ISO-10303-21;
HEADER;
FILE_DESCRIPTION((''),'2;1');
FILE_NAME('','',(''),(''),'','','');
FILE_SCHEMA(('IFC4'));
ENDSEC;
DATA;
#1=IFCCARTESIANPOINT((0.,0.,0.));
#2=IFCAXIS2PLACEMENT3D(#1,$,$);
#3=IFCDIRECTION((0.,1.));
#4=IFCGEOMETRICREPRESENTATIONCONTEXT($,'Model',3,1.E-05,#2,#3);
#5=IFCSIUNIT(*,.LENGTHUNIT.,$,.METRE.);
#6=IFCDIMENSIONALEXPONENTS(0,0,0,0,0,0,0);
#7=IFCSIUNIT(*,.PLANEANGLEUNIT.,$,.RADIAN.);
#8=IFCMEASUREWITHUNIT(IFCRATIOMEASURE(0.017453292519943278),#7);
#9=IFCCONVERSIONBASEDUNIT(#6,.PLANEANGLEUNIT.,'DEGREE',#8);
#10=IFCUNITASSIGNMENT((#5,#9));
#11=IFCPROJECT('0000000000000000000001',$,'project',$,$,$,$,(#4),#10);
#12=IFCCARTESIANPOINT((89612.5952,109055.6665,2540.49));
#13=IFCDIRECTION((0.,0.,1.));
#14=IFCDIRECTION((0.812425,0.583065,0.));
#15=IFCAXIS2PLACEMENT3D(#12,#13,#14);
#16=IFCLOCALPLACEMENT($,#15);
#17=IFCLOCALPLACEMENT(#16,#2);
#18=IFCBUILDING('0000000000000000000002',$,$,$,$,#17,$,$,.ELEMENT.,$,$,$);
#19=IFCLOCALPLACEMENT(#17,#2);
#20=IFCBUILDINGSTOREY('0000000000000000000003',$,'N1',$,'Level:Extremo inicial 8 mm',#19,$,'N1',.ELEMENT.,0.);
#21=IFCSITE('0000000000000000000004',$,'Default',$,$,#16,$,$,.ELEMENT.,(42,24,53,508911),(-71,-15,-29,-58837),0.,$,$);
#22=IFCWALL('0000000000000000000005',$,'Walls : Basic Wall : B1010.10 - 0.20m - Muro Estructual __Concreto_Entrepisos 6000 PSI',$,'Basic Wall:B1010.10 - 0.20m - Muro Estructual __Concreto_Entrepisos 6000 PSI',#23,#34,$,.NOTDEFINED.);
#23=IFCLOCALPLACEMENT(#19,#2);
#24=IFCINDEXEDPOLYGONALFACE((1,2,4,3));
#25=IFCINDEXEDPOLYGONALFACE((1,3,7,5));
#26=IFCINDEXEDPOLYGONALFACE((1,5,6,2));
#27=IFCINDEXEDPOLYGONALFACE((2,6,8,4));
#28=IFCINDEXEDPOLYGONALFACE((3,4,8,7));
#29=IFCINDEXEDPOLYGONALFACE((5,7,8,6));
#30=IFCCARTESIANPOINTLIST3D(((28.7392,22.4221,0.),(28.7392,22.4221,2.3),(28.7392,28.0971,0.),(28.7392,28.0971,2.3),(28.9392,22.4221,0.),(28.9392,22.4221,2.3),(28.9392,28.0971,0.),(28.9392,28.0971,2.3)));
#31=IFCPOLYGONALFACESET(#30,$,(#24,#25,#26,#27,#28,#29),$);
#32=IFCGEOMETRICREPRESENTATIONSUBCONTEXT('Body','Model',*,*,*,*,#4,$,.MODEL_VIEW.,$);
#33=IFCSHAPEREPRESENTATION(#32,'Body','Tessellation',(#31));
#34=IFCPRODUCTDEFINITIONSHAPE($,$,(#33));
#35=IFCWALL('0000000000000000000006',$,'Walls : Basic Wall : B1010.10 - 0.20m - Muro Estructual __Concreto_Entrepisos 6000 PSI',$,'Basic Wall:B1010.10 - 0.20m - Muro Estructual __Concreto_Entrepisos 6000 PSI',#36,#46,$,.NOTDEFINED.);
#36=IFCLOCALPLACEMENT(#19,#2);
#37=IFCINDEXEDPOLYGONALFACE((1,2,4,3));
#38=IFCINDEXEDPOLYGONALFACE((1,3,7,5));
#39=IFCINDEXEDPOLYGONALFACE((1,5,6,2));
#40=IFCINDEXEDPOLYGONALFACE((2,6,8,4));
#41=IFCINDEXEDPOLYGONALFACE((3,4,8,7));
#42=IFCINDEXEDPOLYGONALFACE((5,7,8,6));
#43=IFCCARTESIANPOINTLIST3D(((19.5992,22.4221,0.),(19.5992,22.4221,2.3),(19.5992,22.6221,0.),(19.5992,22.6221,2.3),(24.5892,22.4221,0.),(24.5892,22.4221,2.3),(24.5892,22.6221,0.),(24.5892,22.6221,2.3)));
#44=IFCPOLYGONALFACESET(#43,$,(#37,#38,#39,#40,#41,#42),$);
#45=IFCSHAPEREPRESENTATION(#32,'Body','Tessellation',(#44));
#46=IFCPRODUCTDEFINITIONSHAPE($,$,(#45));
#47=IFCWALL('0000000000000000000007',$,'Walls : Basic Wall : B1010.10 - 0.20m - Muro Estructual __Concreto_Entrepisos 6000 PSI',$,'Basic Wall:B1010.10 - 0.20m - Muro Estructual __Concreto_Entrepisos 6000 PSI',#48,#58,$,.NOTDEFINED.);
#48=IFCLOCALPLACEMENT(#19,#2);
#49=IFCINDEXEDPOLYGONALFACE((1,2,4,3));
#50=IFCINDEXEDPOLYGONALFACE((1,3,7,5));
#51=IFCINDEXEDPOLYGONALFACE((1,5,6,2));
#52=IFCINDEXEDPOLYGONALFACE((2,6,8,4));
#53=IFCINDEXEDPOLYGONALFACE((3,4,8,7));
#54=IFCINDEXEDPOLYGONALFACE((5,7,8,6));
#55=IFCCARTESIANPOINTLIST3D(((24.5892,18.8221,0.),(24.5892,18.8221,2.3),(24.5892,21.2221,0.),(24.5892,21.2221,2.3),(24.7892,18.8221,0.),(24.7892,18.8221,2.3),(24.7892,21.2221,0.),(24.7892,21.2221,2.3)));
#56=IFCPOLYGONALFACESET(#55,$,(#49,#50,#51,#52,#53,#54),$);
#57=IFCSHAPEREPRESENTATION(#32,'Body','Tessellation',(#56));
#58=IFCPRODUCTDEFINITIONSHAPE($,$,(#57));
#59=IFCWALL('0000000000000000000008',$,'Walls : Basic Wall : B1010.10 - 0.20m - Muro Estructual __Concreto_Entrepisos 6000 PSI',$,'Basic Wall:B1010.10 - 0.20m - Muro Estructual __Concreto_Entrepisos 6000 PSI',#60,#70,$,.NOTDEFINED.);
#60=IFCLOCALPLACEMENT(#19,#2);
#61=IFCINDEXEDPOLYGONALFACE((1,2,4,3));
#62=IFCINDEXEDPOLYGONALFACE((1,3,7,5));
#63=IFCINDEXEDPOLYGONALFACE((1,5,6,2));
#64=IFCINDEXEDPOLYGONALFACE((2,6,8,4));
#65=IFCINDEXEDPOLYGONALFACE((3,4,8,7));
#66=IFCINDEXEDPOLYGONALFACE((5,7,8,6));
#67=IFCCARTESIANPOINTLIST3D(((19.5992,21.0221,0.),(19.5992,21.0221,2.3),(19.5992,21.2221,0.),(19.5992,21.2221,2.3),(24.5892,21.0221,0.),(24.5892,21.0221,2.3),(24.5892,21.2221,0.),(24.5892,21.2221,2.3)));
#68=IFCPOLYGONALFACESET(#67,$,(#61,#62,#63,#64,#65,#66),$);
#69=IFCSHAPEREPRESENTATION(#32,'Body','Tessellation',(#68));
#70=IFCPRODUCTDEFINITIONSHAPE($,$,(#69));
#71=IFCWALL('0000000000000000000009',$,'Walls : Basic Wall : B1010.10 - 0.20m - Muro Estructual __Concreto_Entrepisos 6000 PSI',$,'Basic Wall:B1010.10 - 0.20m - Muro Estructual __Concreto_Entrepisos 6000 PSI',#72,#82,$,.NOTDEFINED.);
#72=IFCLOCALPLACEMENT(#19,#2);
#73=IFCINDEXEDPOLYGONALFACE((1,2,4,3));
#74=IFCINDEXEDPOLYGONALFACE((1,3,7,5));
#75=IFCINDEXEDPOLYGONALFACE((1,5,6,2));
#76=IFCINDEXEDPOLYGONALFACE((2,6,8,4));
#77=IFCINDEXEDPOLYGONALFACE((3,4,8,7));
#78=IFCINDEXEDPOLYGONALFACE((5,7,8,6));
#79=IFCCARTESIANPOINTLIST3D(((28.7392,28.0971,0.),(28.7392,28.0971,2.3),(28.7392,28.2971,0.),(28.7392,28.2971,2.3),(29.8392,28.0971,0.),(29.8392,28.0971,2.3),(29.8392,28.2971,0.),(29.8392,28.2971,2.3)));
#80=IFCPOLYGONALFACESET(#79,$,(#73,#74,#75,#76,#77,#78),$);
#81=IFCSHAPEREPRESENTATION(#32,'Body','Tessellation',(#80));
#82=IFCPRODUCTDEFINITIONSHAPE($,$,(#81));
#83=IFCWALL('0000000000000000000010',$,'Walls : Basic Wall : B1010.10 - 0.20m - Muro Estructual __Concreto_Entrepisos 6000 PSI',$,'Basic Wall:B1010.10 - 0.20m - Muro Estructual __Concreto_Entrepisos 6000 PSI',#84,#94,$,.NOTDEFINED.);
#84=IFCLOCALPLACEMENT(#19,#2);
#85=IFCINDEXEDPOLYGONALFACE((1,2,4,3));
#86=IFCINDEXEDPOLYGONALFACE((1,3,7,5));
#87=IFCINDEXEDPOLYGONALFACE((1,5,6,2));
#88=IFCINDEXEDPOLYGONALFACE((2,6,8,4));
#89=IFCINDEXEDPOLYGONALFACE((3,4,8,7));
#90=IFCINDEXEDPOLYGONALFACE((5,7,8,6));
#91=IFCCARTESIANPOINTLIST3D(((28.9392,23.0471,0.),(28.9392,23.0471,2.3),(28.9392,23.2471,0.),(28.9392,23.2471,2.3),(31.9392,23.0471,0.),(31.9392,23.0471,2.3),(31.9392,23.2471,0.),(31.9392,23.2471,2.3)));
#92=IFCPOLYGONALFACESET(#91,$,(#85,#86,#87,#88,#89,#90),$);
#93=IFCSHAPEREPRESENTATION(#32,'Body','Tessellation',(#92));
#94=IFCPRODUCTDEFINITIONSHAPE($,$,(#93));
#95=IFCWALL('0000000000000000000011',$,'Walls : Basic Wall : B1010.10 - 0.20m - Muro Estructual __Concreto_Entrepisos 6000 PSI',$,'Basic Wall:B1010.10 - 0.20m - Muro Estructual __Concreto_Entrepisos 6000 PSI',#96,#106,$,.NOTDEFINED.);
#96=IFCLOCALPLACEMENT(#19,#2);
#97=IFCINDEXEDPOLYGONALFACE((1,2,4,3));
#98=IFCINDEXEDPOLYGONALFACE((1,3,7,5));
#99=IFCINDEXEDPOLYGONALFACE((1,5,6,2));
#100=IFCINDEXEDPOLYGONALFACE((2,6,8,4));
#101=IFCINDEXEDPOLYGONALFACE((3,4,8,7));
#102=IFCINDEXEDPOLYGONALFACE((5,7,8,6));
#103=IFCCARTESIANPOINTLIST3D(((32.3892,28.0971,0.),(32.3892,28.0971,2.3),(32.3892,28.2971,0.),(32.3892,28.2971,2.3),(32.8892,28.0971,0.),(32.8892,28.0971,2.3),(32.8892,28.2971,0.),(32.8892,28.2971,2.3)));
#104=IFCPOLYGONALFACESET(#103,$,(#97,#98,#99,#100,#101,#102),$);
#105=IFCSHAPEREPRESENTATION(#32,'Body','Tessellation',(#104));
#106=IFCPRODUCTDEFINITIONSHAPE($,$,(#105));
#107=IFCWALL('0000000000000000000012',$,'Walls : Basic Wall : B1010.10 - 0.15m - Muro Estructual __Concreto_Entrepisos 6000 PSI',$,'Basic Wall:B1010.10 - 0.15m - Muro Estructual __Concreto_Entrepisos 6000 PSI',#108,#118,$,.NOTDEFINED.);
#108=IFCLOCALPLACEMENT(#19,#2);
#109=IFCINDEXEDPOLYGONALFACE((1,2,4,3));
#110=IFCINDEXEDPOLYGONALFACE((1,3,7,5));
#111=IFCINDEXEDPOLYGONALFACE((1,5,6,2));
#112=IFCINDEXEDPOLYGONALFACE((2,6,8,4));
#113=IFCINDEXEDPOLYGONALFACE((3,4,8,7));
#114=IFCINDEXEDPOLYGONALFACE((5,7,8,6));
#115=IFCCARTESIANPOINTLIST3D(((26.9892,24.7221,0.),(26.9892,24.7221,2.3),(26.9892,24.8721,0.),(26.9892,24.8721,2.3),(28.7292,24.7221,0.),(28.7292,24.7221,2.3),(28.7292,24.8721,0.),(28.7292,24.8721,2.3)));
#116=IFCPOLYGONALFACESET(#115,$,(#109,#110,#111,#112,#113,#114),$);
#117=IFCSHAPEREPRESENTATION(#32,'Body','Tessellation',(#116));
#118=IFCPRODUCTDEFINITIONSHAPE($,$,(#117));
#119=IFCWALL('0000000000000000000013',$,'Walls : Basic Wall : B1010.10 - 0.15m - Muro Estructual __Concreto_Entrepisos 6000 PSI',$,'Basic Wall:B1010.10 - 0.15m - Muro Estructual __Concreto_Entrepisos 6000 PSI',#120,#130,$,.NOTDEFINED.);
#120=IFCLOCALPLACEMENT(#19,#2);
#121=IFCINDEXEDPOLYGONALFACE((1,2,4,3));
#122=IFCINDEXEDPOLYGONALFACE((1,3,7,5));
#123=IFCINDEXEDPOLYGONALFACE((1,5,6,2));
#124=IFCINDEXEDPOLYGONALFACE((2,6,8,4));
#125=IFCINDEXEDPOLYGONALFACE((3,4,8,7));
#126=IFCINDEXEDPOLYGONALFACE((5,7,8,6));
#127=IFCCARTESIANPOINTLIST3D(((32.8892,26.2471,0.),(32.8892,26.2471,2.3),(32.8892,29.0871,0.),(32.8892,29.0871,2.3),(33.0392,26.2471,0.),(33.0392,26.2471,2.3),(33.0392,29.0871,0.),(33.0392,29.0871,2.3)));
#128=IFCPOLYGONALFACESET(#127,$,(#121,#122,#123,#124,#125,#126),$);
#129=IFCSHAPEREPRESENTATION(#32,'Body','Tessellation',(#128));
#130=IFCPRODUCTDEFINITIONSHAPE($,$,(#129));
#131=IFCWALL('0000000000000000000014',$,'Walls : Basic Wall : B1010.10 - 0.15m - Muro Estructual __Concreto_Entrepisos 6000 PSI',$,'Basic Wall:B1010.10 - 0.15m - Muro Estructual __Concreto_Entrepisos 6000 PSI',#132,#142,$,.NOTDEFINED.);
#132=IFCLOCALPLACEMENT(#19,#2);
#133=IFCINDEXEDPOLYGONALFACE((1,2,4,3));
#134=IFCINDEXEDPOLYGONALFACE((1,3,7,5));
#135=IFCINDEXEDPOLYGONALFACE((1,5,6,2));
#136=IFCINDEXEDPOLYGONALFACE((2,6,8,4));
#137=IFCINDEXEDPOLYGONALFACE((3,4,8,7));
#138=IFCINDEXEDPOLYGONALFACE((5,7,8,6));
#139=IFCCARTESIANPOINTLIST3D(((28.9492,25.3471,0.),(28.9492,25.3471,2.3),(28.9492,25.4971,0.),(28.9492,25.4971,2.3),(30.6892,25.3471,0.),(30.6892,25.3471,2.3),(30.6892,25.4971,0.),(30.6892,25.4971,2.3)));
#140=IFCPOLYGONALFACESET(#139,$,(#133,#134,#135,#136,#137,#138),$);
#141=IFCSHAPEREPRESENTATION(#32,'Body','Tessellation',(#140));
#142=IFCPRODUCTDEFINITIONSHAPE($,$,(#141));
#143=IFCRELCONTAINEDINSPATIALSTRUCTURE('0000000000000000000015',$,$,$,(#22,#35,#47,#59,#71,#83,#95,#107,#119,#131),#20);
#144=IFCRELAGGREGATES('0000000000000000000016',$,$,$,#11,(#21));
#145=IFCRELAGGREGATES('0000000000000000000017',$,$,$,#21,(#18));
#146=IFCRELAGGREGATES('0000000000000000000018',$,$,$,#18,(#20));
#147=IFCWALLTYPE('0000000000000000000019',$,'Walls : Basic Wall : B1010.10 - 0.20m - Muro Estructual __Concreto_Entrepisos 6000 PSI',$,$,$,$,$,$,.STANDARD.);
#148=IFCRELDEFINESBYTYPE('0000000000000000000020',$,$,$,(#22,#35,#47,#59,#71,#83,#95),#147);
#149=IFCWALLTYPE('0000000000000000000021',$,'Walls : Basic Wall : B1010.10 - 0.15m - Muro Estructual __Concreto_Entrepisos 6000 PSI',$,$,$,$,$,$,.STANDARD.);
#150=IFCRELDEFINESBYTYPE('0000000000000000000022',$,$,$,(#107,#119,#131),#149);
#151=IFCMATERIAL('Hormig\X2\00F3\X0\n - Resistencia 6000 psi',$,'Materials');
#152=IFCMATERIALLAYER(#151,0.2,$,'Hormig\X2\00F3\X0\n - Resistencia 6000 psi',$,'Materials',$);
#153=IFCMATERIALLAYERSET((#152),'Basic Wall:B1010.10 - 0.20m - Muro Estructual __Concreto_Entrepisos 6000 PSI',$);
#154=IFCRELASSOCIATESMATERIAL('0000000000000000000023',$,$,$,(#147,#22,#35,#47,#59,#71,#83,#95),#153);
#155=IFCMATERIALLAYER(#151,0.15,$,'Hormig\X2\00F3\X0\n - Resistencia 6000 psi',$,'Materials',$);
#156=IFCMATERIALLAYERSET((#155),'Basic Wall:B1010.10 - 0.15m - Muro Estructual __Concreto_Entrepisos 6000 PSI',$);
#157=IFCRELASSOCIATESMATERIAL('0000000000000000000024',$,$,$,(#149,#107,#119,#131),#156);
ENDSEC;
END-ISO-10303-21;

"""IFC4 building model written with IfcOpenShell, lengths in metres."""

from ifc_helpers import new_model, entity, si_unit, converted_unit, direction, frame, frame_2d, origin, place, context, subcontext, project, spatial, rectangle, extrude, material, layer, layer_set, layer_usage, type_object, element, save


model = new_model("IFC4")

# Units and contexts
model_context = context("Model", 3, precision=1e-05, world=origin(), true_north=direction((0.0, 1.0)))
body_context = subcontext(model_context, "Body", "Model", "MODEL_VIEW")
ifc_project = project(units=[si_unit("LENGTHUNIT", "METRE"), converted_unit("PLANEANGLEUNIT", "DEGREE", entity("IfcRatioMeasure", 0.017453292519943278), si_unit("PLANEANGLEUNIT", "RADIAN"), dimensions=[0, 0, 0, 0, 0, 0, 0])], contexts=[model_context])

# Site, building, storey
site_placement = place(None, frame((89612.5952, 109055.6665, 2540.49), z_axis=(0.0, 0.0, 1.0), x_axis=(0.812425, 0.583065, 0.0)))
site = spatial("IfcSite", under=ifc_project, at=site_placement, Name="Default", CompositionType="ELEMENT", RefLatitude=(42, 24, 53, 508911), RefLongitude=(-71, -15, -29, -58837), RefElevation=0.0)
building_placement = place(site_placement, origin())
building = spatial("IfcBuilding", under=site, at=building_placement, CompositionType="ELEMENT")
storey_placement = place(building_placement, origin())
storey = spatial("IfcBuildingStorey", under=building, at=storey_placement, Name="N1", ObjectType="Level:Extremo inicial 8 mm", LongName="N1", CompositionType="ELEMENT", Elevation=0.0)

# Walls
ifc_material_1 = material(Name="Hormigón - Resistencia 6000 psi", Category="Materials")
ifc_layer_1 = layer(ifc_material_1, 0.2, Name="Hormigón - Resistencia 6000 psi", Category="Materials")
ifc_layer_set_1 = layer_set([ifc_layer_1], Name="Basic Wall:B1010.10 - 0.20m - Muro Estructual __Concreto_Entrepisos 6000 PSI")
ifc_layer_usage_1 = layer_usage(ifc_layer_set_1, "AXIS2", "NEGATIVE", 0.1)
wall_type_1 = type_object("IfcWallType", Name="Walls : Basic Wall : B1010.10 - 0.20m - Muro Estructual __Concreto_Entrepisos 6000 PSI", PredefinedType="STANDARD", material=ifc_layer_set_1)
wall_1_placement = place(storey_placement, frame((28.8392, 28.0971, 0.0), z_axis=(0.0, 0.0, 1.0), x_axis=(0.0, -1.0, 0.0)))
element("IfcWall", 1, at=wall_1_placement, inside=storey, type_object=wall_type_1, material=ifc_layer_usage_1, Name="Walls : Basic Wall : B1010.10 - 0.20m - Muro Estructual __Concreto_Entrepisos 6000 PSI", ObjectType="Basic Wall:B1010.10 - 0.20m - Muro Estructual __Concreto_Entrepisos 6000 PSI", PredefinedType="NOTDEFINED", context=body_context, shape_type="SweptSolid", body=[
    extrude(rectangle(XDim=5.675, YDim=0.2, at=frame_2d((2.8375, 0.0), x_axis=(-1.0, 0.0))), origin(), (0.0, 0.0, 1.0), 2.3),
])
ifc_layer_usage_2 = layer_usage(ifc_layer_set_1, "AXIS2", "NEGATIVE", 0.1)
wall_2_placement = place(storey_placement, frame((24.5892, 22.5221, 0.0), z_axis=(0.0, 0.0, 1.0), x_axis=(-1.0, 0.0, 0.0)))
element("IfcWall", 2, at=wall_2_placement, inside=storey, type_object=wall_type_1, material=ifc_layer_usage_2, Name="Walls : Basic Wall : B1010.10 - 0.20m - Muro Estructual __Concreto_Entrepisos 6000 PSI", ObjectType="Basic Wall:B1010.10 - 0.20m - Muro Estructual __Concreto_Entrepisos 6000 PSI", PredefinedType="NOTDEFINED", context=body_context, shape_type="SweptSolid", body=[
    extrude(rectangle(XDim=4.99, YDim=0.2, at=frame_2d((2.495, 0.0), x_axis=(-1.0, 0.0))), origin(), (0.0, 0.0, 1.0), 2.3),
])
ifc_layer_usage_3 = layer_usage(ifc_layer_set_1, "AXIS2", "POSITIVE", -0.1)
wall_3_placement = place(storey_placement, frame((24.6892, 18.8221, 0.0), z_axis=(0.0, 0.0, 1.0), x_axis=(0.0, 1.0, 0.0)))
element("IfcWall", 3, at=wall_3_placement, inside=storey, type_object=wall_type_1, material=ifc_layer_usage_3, Name="Walls : Basic Wall : B1010.10 - 0.20m - Muro Estructual __Concreto_Entrepisos 6000 PSI", ObjectType="Basic Wall:B1010.10 - 0.20m - Muro Estructual __Concreto_Entrepisos 6000 PSI", PredefinedType="NOTDEFINED", context=body_context, shape_type="SweptSolid", body=[
    extrude(rectangle(XDim=2.4, YDim=0.2, at=frame_2d((1.2, 0.0), x_axis=(-1.0, 0.0))), origin(), (0.0, 0.0, 1.0), 2.3),
])
ifc_layer_usage_4 = layer_usage(ifc_layer_set_1, "AXIS2", "POSITIVE", -0.1)
wall_4_placement = place(storey_placement, frame((24.5892, 21.1221, 0.0), z_axis=(0.0, 0.0, 1.0), x_axis=(-1.0, 0.0, 0.0)))
element("IfcWall", 4, at=wall_4_placement, inside=storey, type_object=wall_type_1, material=ifc_layer_usage_4, Name="Walls : Basic Wall : B1010.10 - 0.20m - Muro Estructual __Concreto_Entrepisos 6000 PSI", ObjectType="Basic Wall:B1010.10 - 0.20m - Muro Estructual __Concreto_Entrepisos 6000 PSI", PredefinedType="NOTDEFINED", context=body_context, shape_type="SweptSolid", body=[
    extrude(rectangle(XDim=4.99, YDim=0.2, at=frame_2d((2.495, 0.0), x_axis=(-1.0, 0.0))), origin(), (0.0, 0.0, 1.0), 2.3),
])
ifc_layer_usage_5 = layer_usage(ifc_layer_set_1, "AXIS2", "POSITIVE", -0.1)
wall_5_placement = place(storey_placement, frame((29.8392, 28.1971, 0.0), z_axis=(0.0, 0.0, 1.0), x_axis=(-1.0, 0.0, 0.0)))
element("IfcWall", 5, at=wall_5_placement, inside=storey, type_object=wall_type_1, material=ifc_layer_usage_5, Name="Walls : Basic Wall : B1010.10 - 0.20m - Muro Estructual __Concreto_Entrepisos 6000 PSI", ObjectType="Basic Wall:B1010.10 - 0.20m - Muro Estructual __Concreto_Entrepisos 6000 PSI", PredefinedType="NOTDEFINED", context=body_context, shape_type="SweptSolid", body=[
    extrude(rectangle(XDim=1.1, YDim=0.2, at=frame_2d((0.55, 0.0), x_axis=(-1.0, 0.0))), origin(), (0.0, 0.0, 1.0), 2.3),
])
ifc_layer_usage_6 = layer_usage(ifc_layer_set_1, "AXIS2", "POSITIVE", -0.1)
wall_6_placement = place(storey_placement, frame((28.9392, 23.1471, 0.0)))
element("IfcWall", 6, at=wall_6_placement, inside=storey, type_object=wall_type_1, material=ifc_layer_usage_6, Name="Walls : Basic Wall : B1010.10 - 0.20m - Muro Estructual __Concreto_Entrepisos 6000 PSI", ObjectType="Basic Wall:B1010.10 - 0.20m - Muro Estructual __Concreto_Entrepisos 6000 PSI", PredefinedType="NOTDEFINED", context=body_context, shape_type="SweptSolid", body=[
    extrude(rectangle(XDim=3.0, YDim=0.2, at=frame_2d((1.5, 0.0), x_axis=(-1.0, 0.0))), origin(), (0.0, 0.0, 1.0), 2.3),
])
ifc_layer_usage_7 = layer_usage(ifc_layer_set_1, "AXIS2", "POSITIVE", -0.1)
wall_7_placement = place(storey_placement, frame((32.3892, 28.1971, 0.0)))
element("IfcWall", 7, at=wall_7_placement, inside=storey, type_object=wall_type_1, material=ifc_layer_usage_7, Name="Walls : Basic Wall : B1010.10 - 0.20m - Muro Estructual __Concreto_Entrepisos 6000 PSI", ObjectType="Basic Wall:B1010.10 - 0.20m - Muro Estructual __Concreto_Entrepisos 6000 PSI", PredefinedType="NOTDEFINED", context=body_context, shape_type="SweptSolid", body=[
    extrude(rectangle(XDim=0.5, YDim=0.2, at=frame_2d((0.25, 0.0), x_axis=(-1.0, 0.0))), origin(), (0.0, 0.0, 1.0), 2.3),
])
ifc_layer_2 = layer(ifc_material_1, 0.15, Name="Hormigón - Resistencia 6000 psi", Category="Materials")
ifc_layer_set_2 = layer_set([ifc_layer_2], Name="Basic Wall:B1010.10 - 0.15m - Muro Estructual __Concreto_Entrepisos 6000 PSI")
ifc_layer_usage_8 = layer_usage(ifc_layer_set_2, "AXIS2", "NEGATIVE", 0.075)
wall_type_2 = type_object("IfcWallType", Name="Walls : Basic Wall : B1010.10 - 0.15m - Muro Estructual __Concreto_Entrepisos 6000 PSI", PredefinedType="STANDARD", material=ifc_layer_set_2)
wall_8_placement = place(storey_placement, frame((26.9892, 24.7971, 0.0)))
element("IfcWall", 8, at=wall_8_placement, inside=storey, type_object=wall_type_2, material=ifc_layer_usage_8, Name="Walls : Basic Wall : B1010.10 - 0.15m - Muro Estructual __Concreto_Entrepisos 6000 PSI", ObjectType="Basic Wall:B1010.10 - 0.15m - Muro Estructual __Concreto_Entrepisos 6000 PSI", PredefinedType="NOTDEFINED", context=body_context, shape_type="SweptSolid", body=[
    extrude(rectangle(XDim=1.74, YDim=0.15, at=frame_2d((0.87, 0.0), x_axis=(-1.0, 0.0))), origin(), (0.0, 0.0, 1.0), 2.3),
])
ifc_layer_usage_9 = layer_usage(ifc_layer_set_2, "AXIS2", "POSITIVE", -0.075)
wall_9_placement = place(storey_placement, frame((32.9642, 29.0871, 0.0), z_axis=(0.0, 0.0, 1.0), x_axis=(0.0, -1.0, 0.0)))
element("IfcWall", 9, at=wall_9_placement, inside=storey, type_object=wall_type_2, material=ifc_layer_usage_9, Name="Walls : Basic Wall : B1010.10 - 0.15m - Muro Estructual __Concreto_Entrepisos 6000 PSI", ObjectType="Basic Wall:B1010.10 - 0.15m - Muro Estructual __Concreto_Entrepisos 6000 PSI", PredefinedType="NOTDEFINED", context=body_context, shape_type="SweptSolid", body=[
    extrude(rectangle(XDim=2.84, YDim=0.15, at=frame_2d((1.42, 0.0), x_axis=(-1.0, 0.0))), origin(), (0.0, 0.0, 1.0), 2.3),
])
ifc_layer_usage_10 = layer_usage(ifc_layer_set_2, "AXIS2", "POSITIVE", -0.075)
wall_10_placement = place(storey_placement, frame((30.6892, 25.4221, 0.0), z_axis=(0.0, 0.0, 1.0), x_axis=(-1.0, 0.0, 0.0)))
element("IfcWall", 10, at=wall_10_placement, inside=storey, type_object=wall_type_2, material=ifc_layer_usage_10, Name="Walls : Basic Wall : B1010.10 - 0.15m - Muro Estructual __Concreto_Entrepisos 6000 PSI", ObjectType="Basic Wall:B1010.10 - 0.15m - Muro Estructual __Concreto_Entrepisos 6000 PSI", PredefinedType="NOTDEFINED", context=body_context, shape_type="SweptSolid", body=[
    extrude(rectangle(XDim=1.74, YDim=0.15, at=frame_2d((0.87, 0.0), x_axis=(-1.0, 0.0))), origin(), (0.0, 0.0, 1.0), 2.3),
])

save(model, "model.ifc")
